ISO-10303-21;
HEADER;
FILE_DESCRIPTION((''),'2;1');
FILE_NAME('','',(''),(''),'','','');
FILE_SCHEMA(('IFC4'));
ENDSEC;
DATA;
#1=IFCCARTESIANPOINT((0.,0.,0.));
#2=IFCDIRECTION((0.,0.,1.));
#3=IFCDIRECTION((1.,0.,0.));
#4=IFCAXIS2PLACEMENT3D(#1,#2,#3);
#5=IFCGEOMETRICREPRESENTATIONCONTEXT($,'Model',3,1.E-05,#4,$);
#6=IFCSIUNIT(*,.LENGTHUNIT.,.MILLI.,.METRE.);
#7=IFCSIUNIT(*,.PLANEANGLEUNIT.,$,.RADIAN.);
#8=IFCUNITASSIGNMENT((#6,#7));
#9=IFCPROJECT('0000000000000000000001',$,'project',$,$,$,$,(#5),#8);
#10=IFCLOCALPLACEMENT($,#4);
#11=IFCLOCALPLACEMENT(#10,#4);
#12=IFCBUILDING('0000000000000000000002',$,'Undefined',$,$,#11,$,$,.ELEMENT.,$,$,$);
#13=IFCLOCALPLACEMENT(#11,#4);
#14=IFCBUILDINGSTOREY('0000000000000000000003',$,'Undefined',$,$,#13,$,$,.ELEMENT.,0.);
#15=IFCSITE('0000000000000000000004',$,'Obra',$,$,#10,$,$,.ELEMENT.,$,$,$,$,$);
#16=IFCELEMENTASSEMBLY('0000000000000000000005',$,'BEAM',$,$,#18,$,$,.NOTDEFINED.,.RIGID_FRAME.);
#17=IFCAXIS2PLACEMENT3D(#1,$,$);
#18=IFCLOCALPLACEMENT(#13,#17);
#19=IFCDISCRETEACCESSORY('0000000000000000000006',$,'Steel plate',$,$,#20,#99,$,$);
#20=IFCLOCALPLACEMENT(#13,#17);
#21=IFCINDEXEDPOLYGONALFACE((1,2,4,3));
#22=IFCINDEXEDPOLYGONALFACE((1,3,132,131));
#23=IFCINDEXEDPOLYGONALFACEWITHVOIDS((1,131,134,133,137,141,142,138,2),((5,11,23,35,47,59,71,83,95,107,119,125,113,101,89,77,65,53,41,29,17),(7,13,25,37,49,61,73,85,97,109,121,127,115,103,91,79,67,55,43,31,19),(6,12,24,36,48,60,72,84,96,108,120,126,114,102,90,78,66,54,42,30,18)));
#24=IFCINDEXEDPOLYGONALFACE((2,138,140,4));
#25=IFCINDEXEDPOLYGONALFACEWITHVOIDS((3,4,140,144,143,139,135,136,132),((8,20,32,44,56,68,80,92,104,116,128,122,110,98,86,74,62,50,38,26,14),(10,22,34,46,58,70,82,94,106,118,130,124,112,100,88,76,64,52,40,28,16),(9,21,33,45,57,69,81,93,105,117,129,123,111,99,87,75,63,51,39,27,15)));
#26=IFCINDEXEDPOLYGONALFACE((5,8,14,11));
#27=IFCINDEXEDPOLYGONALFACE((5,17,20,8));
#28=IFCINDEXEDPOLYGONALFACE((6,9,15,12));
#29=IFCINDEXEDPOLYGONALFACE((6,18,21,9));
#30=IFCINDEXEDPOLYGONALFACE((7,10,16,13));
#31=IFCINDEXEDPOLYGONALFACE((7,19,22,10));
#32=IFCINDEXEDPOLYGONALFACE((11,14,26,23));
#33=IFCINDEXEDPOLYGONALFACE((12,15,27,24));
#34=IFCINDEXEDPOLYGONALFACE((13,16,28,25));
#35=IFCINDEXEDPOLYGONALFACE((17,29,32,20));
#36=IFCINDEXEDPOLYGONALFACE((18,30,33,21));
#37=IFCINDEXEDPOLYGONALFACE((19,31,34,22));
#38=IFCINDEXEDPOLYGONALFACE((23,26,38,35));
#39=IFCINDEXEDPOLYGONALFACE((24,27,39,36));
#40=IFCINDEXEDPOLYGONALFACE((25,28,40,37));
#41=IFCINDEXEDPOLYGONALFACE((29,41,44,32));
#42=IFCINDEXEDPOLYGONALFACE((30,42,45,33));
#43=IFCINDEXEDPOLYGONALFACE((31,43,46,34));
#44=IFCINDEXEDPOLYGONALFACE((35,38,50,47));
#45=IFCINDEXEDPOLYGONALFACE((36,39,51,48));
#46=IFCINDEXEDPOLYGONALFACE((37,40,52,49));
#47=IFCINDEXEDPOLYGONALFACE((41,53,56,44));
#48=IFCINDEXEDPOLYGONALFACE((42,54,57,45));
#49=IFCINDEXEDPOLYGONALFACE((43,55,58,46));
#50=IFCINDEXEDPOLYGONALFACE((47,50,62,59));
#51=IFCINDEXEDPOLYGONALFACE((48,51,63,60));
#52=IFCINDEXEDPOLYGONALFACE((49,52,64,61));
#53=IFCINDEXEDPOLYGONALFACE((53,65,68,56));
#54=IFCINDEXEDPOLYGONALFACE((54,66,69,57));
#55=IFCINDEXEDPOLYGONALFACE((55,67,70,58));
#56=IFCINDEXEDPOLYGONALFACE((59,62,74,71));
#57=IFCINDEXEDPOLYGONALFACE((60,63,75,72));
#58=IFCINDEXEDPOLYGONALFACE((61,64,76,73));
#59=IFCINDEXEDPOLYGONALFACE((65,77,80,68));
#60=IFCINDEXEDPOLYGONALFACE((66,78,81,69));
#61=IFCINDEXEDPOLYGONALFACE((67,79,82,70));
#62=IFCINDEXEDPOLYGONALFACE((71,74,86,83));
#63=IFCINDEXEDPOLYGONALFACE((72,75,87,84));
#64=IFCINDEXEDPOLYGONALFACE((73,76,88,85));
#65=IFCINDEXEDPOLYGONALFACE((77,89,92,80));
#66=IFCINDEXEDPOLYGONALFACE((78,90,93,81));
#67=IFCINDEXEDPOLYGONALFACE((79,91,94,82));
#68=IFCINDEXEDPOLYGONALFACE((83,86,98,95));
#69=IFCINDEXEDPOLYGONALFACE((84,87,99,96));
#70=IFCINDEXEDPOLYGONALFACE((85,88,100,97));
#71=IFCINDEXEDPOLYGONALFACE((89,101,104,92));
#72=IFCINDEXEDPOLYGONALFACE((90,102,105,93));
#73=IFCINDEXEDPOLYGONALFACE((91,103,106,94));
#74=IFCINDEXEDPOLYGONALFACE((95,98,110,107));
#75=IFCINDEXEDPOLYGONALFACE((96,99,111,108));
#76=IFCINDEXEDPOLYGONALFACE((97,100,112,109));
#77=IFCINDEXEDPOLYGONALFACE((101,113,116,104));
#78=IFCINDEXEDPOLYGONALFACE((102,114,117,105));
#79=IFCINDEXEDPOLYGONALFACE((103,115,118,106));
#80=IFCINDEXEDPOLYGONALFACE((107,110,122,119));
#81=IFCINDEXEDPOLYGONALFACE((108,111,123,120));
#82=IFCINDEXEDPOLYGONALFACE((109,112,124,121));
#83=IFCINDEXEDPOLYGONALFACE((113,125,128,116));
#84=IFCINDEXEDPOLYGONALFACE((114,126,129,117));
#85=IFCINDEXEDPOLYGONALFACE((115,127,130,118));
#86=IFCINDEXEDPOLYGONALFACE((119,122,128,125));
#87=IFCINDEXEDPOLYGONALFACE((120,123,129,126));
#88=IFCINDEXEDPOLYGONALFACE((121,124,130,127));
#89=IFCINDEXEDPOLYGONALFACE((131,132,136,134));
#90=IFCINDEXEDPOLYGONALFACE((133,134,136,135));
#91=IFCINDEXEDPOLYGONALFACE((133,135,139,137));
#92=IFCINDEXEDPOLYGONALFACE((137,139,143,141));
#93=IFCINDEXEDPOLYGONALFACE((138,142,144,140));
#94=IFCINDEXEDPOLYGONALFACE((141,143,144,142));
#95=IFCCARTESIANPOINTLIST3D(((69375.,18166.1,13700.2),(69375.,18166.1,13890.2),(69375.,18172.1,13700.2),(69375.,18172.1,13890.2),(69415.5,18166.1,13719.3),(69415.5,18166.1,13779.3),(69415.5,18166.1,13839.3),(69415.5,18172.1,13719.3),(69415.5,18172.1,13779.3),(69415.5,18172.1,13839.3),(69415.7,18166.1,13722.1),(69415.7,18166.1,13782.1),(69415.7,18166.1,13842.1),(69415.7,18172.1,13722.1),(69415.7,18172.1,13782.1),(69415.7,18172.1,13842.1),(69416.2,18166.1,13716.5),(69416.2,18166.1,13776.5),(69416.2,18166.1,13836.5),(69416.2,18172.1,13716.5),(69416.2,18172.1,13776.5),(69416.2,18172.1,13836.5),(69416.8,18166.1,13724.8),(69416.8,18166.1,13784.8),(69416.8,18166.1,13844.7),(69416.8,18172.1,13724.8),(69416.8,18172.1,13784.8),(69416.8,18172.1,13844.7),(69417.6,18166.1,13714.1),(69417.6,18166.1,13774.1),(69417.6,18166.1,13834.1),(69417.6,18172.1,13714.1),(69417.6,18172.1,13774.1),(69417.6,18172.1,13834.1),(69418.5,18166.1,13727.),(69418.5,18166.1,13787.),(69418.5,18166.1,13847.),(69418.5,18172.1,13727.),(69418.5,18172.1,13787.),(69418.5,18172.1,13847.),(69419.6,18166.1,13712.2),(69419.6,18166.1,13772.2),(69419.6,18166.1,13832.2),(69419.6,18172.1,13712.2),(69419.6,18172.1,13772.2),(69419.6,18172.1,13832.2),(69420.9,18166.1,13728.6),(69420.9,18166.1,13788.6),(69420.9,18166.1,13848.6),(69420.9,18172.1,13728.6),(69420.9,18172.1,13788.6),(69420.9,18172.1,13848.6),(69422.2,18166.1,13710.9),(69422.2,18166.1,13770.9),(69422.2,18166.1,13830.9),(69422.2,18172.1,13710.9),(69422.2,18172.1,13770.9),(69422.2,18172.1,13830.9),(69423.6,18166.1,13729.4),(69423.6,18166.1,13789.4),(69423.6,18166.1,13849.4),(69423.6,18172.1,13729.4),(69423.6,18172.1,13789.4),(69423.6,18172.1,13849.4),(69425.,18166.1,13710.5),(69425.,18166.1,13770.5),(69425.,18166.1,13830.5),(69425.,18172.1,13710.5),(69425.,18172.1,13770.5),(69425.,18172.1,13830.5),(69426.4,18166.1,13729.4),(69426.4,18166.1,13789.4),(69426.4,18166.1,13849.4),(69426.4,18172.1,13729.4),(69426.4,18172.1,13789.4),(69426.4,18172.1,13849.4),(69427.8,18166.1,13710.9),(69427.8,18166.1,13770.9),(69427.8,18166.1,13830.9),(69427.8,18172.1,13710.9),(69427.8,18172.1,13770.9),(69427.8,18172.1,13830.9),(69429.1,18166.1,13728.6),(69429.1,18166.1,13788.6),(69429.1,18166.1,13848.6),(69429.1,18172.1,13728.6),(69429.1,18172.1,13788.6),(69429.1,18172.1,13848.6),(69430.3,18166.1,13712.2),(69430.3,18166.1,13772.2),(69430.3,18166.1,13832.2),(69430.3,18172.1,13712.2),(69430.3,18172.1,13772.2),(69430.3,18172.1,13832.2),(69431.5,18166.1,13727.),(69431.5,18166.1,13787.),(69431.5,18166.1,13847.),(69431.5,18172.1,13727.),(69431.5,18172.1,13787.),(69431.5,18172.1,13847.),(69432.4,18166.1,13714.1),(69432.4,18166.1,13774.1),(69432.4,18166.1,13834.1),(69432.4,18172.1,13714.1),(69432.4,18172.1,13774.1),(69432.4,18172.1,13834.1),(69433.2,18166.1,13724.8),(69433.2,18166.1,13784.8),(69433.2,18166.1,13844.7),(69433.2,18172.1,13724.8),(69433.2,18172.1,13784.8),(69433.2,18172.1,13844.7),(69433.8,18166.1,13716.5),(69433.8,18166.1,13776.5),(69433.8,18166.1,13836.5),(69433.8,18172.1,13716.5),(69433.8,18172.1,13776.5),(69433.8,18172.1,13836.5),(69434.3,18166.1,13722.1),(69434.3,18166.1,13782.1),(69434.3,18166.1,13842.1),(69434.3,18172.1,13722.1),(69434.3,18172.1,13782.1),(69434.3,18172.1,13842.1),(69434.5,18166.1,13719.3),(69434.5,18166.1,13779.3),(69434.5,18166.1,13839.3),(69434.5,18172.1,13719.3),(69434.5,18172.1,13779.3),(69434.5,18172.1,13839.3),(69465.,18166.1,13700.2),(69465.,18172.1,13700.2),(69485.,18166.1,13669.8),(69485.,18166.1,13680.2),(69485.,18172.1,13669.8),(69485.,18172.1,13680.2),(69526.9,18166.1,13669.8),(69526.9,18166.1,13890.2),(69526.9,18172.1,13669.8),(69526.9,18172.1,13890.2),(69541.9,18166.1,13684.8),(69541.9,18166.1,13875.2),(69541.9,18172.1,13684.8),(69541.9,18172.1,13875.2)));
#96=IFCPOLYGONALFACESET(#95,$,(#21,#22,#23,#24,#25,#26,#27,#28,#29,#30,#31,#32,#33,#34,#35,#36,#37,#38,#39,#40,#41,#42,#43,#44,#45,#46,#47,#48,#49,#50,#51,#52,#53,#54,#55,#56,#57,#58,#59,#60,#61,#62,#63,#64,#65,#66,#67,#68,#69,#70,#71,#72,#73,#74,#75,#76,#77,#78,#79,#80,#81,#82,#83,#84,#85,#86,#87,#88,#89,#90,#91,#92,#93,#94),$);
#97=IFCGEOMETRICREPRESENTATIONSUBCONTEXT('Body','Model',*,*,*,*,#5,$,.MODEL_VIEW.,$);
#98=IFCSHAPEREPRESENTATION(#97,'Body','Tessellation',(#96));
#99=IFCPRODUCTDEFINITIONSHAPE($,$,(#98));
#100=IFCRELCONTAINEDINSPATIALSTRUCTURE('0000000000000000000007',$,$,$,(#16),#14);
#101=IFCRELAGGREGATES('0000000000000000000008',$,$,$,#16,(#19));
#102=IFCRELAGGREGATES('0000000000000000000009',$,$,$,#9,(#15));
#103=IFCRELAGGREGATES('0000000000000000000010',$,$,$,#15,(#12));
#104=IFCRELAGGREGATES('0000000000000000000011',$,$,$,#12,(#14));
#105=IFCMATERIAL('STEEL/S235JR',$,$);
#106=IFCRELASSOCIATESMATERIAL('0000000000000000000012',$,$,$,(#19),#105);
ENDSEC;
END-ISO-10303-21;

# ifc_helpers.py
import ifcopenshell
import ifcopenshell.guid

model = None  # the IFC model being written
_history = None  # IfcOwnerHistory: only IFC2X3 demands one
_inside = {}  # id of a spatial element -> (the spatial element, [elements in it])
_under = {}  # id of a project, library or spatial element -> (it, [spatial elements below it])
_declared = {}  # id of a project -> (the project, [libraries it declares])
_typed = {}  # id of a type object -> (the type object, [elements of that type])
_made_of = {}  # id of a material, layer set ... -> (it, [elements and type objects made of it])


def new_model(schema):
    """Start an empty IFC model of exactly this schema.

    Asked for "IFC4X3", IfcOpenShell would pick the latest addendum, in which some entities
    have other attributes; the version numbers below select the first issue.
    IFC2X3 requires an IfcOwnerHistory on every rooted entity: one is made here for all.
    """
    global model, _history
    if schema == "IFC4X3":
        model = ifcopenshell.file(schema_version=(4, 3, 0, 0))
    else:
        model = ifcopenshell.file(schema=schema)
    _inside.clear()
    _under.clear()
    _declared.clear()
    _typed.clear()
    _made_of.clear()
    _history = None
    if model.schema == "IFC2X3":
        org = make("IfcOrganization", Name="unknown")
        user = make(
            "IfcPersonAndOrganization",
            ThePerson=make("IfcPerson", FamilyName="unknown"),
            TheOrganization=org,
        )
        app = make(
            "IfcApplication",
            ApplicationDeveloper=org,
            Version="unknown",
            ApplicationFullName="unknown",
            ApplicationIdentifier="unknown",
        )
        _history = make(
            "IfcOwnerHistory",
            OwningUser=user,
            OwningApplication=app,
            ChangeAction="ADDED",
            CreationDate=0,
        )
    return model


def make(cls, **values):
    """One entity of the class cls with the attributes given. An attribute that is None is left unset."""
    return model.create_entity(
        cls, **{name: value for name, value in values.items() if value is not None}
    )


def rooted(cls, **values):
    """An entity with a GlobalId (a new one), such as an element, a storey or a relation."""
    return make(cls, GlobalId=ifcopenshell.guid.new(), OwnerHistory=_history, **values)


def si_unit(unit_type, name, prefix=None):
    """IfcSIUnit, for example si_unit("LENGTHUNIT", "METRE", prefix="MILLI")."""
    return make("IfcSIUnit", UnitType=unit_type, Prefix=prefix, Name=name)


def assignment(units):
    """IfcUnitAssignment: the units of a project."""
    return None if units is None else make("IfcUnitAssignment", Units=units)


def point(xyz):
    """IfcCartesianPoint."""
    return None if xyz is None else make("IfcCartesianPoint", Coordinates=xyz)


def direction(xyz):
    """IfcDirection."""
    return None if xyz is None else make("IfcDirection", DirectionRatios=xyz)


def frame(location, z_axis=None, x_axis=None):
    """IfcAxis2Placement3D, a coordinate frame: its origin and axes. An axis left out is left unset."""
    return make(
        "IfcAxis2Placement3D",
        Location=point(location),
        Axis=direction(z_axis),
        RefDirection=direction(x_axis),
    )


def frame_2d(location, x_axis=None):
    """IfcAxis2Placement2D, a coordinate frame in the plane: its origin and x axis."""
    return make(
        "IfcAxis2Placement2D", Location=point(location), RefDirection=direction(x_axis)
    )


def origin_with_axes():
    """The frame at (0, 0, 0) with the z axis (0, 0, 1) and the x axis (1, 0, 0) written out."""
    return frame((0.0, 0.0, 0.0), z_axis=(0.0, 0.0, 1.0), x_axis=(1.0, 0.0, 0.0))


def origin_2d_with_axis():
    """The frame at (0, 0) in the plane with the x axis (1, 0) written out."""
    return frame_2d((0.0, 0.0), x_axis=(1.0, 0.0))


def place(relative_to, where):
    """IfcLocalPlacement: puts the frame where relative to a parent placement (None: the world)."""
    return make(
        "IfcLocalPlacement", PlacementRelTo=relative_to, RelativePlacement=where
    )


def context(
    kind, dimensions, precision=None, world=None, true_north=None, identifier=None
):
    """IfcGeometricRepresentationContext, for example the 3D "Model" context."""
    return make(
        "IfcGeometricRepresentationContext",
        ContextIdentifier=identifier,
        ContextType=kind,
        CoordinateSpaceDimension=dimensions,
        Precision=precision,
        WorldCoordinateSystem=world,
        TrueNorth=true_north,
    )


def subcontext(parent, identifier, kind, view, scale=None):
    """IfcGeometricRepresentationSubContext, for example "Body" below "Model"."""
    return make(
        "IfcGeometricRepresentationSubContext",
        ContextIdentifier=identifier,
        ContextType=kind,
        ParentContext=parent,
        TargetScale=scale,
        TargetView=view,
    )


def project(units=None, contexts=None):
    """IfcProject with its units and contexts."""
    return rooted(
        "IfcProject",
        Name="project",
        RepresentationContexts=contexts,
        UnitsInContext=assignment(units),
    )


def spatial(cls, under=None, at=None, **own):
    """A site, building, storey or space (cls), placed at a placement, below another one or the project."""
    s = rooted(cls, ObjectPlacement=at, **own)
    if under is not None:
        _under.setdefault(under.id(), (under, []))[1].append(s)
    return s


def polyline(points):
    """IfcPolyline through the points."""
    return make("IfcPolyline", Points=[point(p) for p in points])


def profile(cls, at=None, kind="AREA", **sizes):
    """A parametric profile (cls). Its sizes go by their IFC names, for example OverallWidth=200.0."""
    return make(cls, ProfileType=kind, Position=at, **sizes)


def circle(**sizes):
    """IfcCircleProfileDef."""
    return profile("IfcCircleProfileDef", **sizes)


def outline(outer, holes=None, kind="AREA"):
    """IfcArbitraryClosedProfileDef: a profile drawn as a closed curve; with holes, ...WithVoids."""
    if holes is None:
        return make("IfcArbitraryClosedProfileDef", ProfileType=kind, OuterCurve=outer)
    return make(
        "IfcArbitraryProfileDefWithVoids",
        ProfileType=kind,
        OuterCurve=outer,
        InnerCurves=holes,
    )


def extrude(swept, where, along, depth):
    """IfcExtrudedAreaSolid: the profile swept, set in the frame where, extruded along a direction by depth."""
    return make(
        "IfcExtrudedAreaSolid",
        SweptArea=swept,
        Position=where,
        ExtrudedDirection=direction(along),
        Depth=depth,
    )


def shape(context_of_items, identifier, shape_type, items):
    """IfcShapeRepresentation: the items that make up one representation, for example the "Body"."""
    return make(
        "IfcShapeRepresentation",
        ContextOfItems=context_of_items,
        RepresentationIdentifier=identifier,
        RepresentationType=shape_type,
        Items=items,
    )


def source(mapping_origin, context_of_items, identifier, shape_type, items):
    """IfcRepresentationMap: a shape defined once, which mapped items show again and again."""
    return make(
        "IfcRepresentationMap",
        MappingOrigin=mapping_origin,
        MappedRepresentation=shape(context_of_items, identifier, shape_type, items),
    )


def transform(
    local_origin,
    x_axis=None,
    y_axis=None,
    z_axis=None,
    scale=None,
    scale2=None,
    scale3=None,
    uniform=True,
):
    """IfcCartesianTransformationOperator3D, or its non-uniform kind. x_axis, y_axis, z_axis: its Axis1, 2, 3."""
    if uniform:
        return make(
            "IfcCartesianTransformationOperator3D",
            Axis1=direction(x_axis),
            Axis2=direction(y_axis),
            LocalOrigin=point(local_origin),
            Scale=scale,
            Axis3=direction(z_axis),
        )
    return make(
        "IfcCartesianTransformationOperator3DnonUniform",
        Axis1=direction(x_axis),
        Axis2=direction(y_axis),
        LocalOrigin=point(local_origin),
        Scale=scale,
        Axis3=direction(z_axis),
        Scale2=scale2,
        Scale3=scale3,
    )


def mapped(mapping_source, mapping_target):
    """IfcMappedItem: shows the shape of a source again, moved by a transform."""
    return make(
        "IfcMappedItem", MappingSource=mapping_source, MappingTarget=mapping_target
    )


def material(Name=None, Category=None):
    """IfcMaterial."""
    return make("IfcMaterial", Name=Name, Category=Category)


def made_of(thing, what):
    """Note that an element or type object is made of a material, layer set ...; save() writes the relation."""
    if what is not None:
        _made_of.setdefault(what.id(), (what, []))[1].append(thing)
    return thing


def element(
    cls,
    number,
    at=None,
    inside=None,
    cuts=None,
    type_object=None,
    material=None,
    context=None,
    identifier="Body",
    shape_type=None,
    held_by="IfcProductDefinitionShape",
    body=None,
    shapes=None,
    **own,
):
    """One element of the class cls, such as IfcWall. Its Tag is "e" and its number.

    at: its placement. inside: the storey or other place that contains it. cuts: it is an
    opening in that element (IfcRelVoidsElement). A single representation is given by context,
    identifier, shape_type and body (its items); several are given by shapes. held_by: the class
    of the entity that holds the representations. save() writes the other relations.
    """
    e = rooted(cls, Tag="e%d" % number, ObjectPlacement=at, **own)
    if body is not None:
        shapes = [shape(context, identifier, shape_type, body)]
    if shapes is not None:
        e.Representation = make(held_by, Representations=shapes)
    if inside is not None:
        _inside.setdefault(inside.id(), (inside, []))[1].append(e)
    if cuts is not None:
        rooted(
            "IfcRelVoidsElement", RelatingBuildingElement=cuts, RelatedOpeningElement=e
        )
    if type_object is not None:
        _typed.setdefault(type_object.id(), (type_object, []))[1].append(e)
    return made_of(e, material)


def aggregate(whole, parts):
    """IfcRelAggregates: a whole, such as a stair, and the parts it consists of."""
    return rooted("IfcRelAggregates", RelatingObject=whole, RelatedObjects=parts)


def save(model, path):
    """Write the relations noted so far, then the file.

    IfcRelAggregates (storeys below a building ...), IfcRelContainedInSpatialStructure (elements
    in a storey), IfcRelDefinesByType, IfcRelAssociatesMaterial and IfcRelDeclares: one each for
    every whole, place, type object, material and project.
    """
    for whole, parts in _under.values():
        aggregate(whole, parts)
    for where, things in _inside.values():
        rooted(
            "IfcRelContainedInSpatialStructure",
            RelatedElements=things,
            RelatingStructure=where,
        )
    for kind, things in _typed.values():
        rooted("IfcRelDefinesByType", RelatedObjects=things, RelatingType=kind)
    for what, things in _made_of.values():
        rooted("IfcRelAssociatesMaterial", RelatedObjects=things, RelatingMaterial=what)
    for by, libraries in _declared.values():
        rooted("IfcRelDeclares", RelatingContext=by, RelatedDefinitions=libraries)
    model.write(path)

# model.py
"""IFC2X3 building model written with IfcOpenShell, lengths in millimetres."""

from ifc_helpers import new_model, si_unit, frame, origin_with_axes, origin_2d_with_axis, place, context, subcontext, project, spatial, polyline, circle, outline, extrude, source, transform, mapped, material, element, aggregate, save


model = new_model("IFC2X3")

# Units and contexts
model_context = context("Model", 3, precision=1e-05, world=origin_with_axes())
body_context = subcontext(model_context, "Body", "Model", "MODEL_VIEW")
ifc_project = project(units=[si_unit("LENGTHUNIT", "METRE", prefix="MILLI"), si_unit("PLANEANGLEUNIT", "RADIAN")], contexts=[model_context])

# Site, building, storey
site_placement = place(None, origin_with_axes())
site = spatial("IfcSite", under=ifc_project, at=site_placement, Name="Obra", CompositionType="ELEMENT")
building_placement = place(site_placement, origin_with_axes())
building = spatial("IfcBuilding", under=site, at=building_placement, Name="Undefined", CompositionType="ELEMENT")
storey_placement = place(building_placement, origin_with_axes())
storey = spatial("IfcBuildingStorey", under=building, at=storey_placement, Name="Undefined", CompositionType="ELEMENT", Elevation=0.0)

# Shared definitions
ifc_material_1 = material(Name="STEEL/S235JR")

# Shared definitions
shared_shape_1 = source(origin_with_axes(), body_context, "Body", "SweptSolid", [
    extrude(circle(Radius=9.5, at=origin_2d_with_axis()), frame((0.0, -9.2, 0.0), z_axis=(0.0, 1.0, 0.0), x_axis=(1.0, 0.0, 0.0)), (0.0, 0.0, 1.0), 6.2),
])

# Element assembly, discrete accessory, opening
assembly_1_placement = place(storey_placement, origin_with_axes())
assembly_1 = element("IfcElementAssembly", 1, at=assembly_1_placement, inside=storey, Name="BEAM", AssemblyPlace="NOTDEFINED", PredefinedType="RIGID_FRAME")
discrete_accessory_1_placement = place(assembly_1_placement, frame((69541.9, 18169.1, 13684.8), z_axis=(0.0, 1.0, 0.0), x_axis=(-0.707107, 0.0, -0.707107)))
discrete_accessory_1 = element("IfcDiscreteAccessory", 2, at=discrete_accessory_1_placement, material=ifc_material_1, Name="Steel plate", context=body_context, shape_type="SweptSolid", body=[
    extrude(outline(polyline([(0.0, 0.0), (21.2, 0.0), (50.8, 29.6), (43.5, 37.0), (43.5, 65.3), (107.1, 128.9), (-27.2, 263.3), (-134.6, 155.8), (-134.6, 134.6), (0.0, 0.0)])), frame((0.0, 0.0, -3.0), z_axis=(0.0, 0.0, 1.0), x_axis=(1.0, 0.0, 0.0)), (0.0, 0.0, 1.0), 6.0),
])
opening_1_placement = place(assembly_1_placement, frame((69475.0, 18163.0, 13890.2), z_axis=(-1.0, 0.0, 0.0), x_axis=(0.0, 0.0, -1.0)))
element("IfcOpeningElement", 3, at=opening_1_placement, cuts=discrete_accessory_1, ObjectType="Opening", context=body_context, shape_type="MappedRepresentation", body=[
    mapped(shared_shape_1, transform((170.2, 0.0, 50.0))),
    mapped(shared_shape_1, transform((110.2, 0.0, 50.0))),
    mapped(shared_shape_1, transform((50.2, 0.0, 50.0))),
])
aggregate(assembly_1, [discrete_accessory_1])

save(model, "model.ifc")
